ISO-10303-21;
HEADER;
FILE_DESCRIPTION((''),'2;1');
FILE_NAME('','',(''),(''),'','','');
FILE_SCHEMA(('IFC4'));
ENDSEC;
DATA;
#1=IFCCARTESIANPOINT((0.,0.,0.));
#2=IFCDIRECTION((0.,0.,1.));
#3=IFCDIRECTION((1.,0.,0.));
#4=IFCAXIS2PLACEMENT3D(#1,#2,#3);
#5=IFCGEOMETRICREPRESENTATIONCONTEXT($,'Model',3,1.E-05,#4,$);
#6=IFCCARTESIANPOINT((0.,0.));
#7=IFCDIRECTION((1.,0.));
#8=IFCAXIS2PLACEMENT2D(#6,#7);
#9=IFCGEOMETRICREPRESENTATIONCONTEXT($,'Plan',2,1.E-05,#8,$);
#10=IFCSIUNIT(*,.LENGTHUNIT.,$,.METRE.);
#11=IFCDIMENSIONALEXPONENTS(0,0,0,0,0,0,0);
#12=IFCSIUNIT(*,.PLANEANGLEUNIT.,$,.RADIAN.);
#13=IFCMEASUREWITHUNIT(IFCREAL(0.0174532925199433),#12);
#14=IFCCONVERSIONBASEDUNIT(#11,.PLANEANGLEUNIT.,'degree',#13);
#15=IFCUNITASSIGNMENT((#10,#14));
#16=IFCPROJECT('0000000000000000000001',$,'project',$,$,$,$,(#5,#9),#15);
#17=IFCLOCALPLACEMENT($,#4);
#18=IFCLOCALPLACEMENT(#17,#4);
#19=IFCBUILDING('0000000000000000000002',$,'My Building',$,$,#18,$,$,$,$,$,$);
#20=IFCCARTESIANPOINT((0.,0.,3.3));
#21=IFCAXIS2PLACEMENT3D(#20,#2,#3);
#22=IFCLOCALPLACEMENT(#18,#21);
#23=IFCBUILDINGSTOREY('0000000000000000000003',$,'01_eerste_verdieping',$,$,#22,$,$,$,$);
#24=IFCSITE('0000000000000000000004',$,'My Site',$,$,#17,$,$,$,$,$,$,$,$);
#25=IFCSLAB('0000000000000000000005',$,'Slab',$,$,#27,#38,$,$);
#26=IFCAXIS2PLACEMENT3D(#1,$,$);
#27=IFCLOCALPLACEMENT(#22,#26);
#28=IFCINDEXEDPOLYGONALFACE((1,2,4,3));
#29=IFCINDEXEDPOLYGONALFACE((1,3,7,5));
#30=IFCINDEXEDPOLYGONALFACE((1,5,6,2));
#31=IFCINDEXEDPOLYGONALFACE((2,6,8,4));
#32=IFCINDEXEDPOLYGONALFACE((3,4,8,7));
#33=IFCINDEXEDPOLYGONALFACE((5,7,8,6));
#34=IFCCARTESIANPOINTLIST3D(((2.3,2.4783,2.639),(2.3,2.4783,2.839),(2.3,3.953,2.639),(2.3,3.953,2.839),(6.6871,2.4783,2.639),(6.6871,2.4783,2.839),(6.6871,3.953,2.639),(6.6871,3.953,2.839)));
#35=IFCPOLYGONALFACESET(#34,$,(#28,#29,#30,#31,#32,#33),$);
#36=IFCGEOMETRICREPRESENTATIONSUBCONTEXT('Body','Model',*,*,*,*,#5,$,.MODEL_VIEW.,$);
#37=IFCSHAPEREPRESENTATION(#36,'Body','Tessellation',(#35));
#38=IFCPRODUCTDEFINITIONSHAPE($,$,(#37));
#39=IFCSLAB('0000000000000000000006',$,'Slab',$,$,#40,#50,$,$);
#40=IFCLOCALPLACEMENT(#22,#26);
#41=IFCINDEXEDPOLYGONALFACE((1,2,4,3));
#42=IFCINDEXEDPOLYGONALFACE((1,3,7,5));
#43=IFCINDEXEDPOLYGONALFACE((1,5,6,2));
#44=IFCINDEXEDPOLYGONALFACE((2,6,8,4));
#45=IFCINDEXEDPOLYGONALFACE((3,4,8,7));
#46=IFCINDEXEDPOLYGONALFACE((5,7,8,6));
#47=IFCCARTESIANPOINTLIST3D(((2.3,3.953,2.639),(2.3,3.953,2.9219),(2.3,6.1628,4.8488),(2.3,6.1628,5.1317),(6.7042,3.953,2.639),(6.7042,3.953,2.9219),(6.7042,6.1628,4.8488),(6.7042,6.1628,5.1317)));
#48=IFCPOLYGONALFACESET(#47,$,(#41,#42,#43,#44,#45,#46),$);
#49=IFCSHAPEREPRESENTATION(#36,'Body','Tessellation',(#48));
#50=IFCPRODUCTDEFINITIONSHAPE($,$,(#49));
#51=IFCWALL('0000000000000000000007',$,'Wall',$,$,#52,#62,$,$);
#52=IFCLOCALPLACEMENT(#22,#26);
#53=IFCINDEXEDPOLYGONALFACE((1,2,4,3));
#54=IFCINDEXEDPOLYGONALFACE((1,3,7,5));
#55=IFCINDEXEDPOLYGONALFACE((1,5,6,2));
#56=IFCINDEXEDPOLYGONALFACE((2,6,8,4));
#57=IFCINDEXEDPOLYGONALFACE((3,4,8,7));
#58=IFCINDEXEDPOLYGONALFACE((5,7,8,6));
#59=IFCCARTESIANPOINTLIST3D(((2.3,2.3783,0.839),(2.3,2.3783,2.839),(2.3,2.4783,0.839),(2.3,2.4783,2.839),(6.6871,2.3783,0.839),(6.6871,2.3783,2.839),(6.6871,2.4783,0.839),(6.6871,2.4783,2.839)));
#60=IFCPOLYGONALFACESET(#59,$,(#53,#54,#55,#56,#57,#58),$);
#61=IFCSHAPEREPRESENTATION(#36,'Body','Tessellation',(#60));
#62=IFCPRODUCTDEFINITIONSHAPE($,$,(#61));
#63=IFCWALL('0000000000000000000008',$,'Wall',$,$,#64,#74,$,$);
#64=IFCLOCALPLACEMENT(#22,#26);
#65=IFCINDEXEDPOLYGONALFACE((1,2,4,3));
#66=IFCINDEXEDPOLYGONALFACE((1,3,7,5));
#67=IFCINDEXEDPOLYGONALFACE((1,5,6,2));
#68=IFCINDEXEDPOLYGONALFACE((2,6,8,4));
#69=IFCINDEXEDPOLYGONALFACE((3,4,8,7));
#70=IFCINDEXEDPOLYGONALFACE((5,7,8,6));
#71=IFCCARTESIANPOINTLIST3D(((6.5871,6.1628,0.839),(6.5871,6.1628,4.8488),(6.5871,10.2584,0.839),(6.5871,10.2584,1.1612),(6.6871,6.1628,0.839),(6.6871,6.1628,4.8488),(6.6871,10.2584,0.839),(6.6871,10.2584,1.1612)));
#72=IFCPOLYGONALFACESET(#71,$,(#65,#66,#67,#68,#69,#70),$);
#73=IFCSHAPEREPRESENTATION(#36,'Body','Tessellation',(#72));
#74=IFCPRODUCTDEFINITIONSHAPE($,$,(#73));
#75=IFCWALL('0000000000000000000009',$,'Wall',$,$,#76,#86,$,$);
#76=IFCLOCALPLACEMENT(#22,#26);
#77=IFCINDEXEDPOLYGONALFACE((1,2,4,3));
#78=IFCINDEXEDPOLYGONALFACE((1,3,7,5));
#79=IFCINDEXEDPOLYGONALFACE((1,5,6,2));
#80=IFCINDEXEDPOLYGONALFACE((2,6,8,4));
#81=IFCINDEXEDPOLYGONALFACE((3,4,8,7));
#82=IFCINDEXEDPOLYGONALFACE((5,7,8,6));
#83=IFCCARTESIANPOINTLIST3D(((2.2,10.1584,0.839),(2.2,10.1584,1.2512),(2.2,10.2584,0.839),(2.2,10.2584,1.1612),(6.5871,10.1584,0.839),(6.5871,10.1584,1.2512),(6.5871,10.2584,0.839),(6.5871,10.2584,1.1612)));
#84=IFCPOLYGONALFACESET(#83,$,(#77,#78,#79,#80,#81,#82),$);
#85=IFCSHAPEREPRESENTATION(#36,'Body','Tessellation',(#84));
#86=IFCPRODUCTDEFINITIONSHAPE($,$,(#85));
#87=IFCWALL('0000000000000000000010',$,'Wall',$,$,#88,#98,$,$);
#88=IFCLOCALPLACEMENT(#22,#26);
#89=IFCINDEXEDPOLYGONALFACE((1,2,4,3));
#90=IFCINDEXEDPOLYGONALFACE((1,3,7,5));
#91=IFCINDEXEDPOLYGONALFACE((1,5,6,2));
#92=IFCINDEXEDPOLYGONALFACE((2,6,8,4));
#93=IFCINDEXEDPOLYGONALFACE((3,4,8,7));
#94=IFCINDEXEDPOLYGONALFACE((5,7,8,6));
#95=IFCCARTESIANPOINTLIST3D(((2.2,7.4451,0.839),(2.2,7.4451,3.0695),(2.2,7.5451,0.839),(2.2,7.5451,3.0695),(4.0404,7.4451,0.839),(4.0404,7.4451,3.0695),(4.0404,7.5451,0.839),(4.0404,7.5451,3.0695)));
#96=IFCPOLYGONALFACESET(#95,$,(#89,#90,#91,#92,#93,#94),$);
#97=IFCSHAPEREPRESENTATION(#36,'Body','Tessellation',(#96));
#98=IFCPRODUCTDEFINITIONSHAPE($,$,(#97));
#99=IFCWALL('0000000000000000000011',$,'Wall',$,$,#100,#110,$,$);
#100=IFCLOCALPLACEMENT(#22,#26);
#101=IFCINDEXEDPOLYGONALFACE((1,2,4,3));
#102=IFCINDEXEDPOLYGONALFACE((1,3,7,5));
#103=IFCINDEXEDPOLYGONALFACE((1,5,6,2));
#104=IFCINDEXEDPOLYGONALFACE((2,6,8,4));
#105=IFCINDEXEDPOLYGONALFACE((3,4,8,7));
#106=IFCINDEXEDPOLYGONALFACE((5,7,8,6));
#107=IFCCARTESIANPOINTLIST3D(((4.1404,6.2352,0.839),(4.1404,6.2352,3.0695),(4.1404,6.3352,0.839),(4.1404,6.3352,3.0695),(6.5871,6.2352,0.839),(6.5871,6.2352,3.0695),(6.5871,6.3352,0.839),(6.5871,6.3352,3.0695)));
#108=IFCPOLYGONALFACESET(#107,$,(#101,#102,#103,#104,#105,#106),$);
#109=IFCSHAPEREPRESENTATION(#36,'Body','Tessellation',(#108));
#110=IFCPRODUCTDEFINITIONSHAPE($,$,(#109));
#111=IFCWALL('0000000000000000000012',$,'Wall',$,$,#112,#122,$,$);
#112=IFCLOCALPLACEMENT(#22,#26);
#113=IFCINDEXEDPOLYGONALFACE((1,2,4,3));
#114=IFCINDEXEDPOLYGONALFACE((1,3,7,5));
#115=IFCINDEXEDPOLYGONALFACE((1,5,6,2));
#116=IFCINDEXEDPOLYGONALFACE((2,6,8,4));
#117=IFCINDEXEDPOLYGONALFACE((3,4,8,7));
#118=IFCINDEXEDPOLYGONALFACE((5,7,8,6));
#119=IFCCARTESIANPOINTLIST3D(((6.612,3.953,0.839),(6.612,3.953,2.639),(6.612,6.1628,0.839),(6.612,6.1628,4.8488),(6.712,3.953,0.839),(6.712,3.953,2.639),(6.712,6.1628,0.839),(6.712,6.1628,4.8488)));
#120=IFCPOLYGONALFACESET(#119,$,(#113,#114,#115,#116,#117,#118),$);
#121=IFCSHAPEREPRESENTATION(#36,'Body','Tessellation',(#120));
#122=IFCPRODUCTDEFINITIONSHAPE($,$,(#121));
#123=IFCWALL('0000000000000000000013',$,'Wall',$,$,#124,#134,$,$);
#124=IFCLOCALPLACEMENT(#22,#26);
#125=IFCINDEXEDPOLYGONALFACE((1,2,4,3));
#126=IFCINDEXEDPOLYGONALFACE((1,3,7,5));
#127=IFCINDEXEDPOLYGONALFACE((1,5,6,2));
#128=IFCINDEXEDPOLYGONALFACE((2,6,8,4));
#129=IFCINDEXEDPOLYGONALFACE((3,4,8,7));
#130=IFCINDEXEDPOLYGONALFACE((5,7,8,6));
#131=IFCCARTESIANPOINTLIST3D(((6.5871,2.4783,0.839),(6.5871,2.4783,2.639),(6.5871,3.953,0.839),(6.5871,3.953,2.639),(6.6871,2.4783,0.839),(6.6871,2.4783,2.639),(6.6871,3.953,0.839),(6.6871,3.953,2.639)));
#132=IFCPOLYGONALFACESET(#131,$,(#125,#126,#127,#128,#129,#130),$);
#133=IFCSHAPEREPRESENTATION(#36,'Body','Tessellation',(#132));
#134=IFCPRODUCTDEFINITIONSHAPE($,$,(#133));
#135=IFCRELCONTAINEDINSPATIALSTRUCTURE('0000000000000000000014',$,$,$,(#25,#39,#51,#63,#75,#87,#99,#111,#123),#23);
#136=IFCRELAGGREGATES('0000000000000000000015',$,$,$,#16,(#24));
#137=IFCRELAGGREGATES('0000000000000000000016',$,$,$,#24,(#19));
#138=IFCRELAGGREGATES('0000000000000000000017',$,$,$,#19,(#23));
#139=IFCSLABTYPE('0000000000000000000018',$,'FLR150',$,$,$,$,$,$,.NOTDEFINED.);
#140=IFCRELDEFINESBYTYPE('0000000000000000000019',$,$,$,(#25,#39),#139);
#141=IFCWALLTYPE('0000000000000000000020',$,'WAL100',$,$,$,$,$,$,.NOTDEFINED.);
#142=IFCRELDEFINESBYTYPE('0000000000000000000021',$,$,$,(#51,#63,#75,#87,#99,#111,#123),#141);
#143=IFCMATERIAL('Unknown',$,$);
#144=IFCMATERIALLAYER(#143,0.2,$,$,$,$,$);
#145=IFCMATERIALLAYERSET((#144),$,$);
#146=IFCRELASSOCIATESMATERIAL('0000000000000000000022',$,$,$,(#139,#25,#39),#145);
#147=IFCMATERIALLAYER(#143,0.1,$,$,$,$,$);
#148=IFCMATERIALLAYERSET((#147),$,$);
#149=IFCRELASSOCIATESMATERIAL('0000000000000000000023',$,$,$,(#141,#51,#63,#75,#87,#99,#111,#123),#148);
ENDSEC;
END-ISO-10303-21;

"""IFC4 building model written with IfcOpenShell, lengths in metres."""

from ifc_helpers import new_model, entity, si_unit, converted_unit, frame, origin_with_axes, origin_2d_with_axis, place, context, subcontext, project, spatial, line, indexed_curve, outline, extrude, clip, halfspace, material, layer, layer_set, layer_usage, type_object, element, save


model = new_model("IFC4")

# Units and contexts
model_context = context("Model", 3, precision=1e-05, world=origin_with_axes())
plan_context = context("Plan", 2, precision=1e-05, world=origin_2d_with_axis())
body_context = subcontext(model_context, "Body", "Model", "MODEL_VIEW")
ifc_project = project(units=[si_unit("LENGTHUNIT", "METRE"), converted_unit("PLANEANGLEUNIT", "degree", entity("IfcReal", 0.0174532925199433), si_unit("PLANEANGLEUNIT", "RADIAN"), dimensions=[0, 0, 0, 0, 0, 0, 0])], contexts=[model_context, plan_context])

# Site, building, storey
site_placement = place(None, origin_with_axes())
site = spatial("IfcSite", under=ifc_project, at=site_placement, Name="My Site")
building_placement = place(site_placement, origin_with_axes())
building = spatial("IfcBuilding", under=site, at=building_placement, Name="My Building")
storey_placement = place(building_placement, frame((0.0, 0.0, 3.3), z_axis=(0.0, 0.0, 1.0), x_axis=(1.0, 0.0, 0.0)))
storey = spatial("IfcBuildingStorey", under=building, at=storey_placement, Name="01_eerste_verdieping")

# Slabs
ifc_material = material(Name="Unknown")
ifc_layer_1 = layer(ifc_material, 0.2)
ifc_layer_set_1 = layer_set([ifc_layer_1])
ifc_layer_usage_1 = layer_usage(ifc_layer_set_1, "AXIS3", "POSITIVE", 0.0)
slab_type = type_object("IfcSlabType", Name="FLR150", PredefinedType="NOTDEFINED", material=ifc_layer_set_1)
slab_1_placement = place(storey_placement, frame((2.3, 2.4783, 2.639), z_axis=(0.0, 0.0, 1.0), x_axis=(1.0, 0.0, 0.0)))
element("IfcSlab", 1, at=slab_1_placement, inside=storey, type_object=slab_type, material=ifc_layer_usage_1, Name="Slab", context=body_context, shape_type="SweptSolid", body=[
    extrude(outline(indexed_curve([(0.0, 0.0), (4.3871, 0.0), (4.3871, 1.4747), (0.0, 1.4747)], segments=[line(4, 1), line(1, 2), line(2, 3), line(3, 4)], self_intersect=False)), None, (0.0, 0.0, 1.0), 0.2),
])
ifc_layer_usage_2 = layer_usage(ifc_layer_set_1, "AXIS3", "POSITIVE", 0.0)
slab_2_placement = place(storey_placement, frame((2.3, 3.953, 2.639), z_axis=(0.0, -0.707107, 0.707107), x_axis=(1.0, 0.0, 0.0)))
element("IfcSlab", 2, at=slab_2_placement, inside=storey, type_object=slab_type, material=ifc_layer_usage_2, Name="Slab", context=body_context, shape_type="SweptSolid", body=[
    extrude(outline(indexed_curve([(4.4042, 0.0), (0.0, 0.0), (0.0, 3.1252), (4.4042, 3.1252)], segments=[line(4, 1), line(1, 2), line(2, 3), line(3, 4)], self_intersect=False)), None, (0.0, 0.707107, 0.707107), 0.2828),
])

# Walls
ifc_layer_2 = layer(ifc_material, 0.1)
ifc_layer_set_2 = layer_set([ifc_layer_2])
ifc_layer_usage_3 = layer_usage(ifc_layer_set_2, "AXIS2", "POSITIVE", 0.0)
wall_type = type_object("IfcWallType", Name="WAL100", PredefinedType="NOTDEFINED", material=ifc_layer_set_2)
wall_1_placement = place(storey_placement, frame((2.3, 2.3783, 0.839), z_axis=(0.0, 0.0, 1.0), x_axis=(1.0, 0.0, 0.0)))
element("IfcWall", 3, at=wall_1_placement, inside=storey, type_object=wall_type, material=ifc_layer_usage_3, Name="Wall", context=body_context, shape_type="SweptSolid", body=[
    extrude(outline(indexed_curve([(0.0, 0.0), (0.0, 0.1), (4.3871, 0.1), (4.3871, 0.0), (0.0, 0.0)], self_intersect=False)), origin_with_axes(), (0.0, 0.0, 1.0), 2.0),
])
ifc_layer_usage_4 = layer_usage(ifc_layer_set_2, "AXIS2", "POSITIVE", 0.0)
wall_2_placement = place(storey_placement, frame((6.5871, 10.2584, 0.839), z_axis=(0.0, 0.0, 1.0), x_axis=(0.0, -1.0, 0.0)))
element("IfcWall", 4, at=wall_2_placement, inside=storey, type_object=wall_type, material=ifc_layer_usage_4, Name="Wall", context=body_context, shape_type="Clipping", body=[
    clip(extrude(outline(indexed_curve([(0.0, 0.0), (0.0, 0.1), (4.0956, 0.1), (4.0956, 0.0), (0.0, 0.0)], self_intersect=False)), origin_with_axes(), (0.0, 0.0, 1.0), 8.1488), halfspace(frame((4.0956, 0.0, 4.0098), z_axis=(-0.669131, 0.0, 0.743145), x_axis=(0.0, 1.0, 0.0)), False)),
])
ifc_layer_usage_5 = layer_usage(ifc_layer_set_2, "AXIS2", "POSITIVE", 0.0)
wall_3_placement = place(storey_placement, frame((6.5871, 10.2584, 0.839), z_axis=(0.0, 0.0, 1.0), x_axis=(-1.0, 0.0, 0.0)))
element("IfcWall", 5, at=wall_3_placement, inside=storey, type_object=wall_type, material=ifc_layer_usage_5, Name="Wall", context=body_context, shape_type="Clipping", body=[
    clip(extrude(outline(indexed_curve([(0.0, 0.0), (0.0, 0.1), (4.3871, 0.1), (4.3871, 0.0), (0.0, 0.0)], self_intersect=False)), origin_with_axes(), (0.0, 0.0, 1.0), 4.5512), halfspace(frame((0.0, 0.1, 0.4122), z_axis=(0.0, -0.669131, 0.743145), x_axis=(-1.0, 0.0, 0.0)), False)),
])
ifc_layer_usage_6 = layer_usage(ifc_layer_set_2, "AXIS2", "POSITIVE", 0.0)
wall_4_placement = place(storey_placement, frame((2.2, 7.4451, 0.839), z_axis=(0.0, 0.0, 1.0), x_axis=(1.0, -0.000001, 0.0)))
element("IfcWall", 6, at=wall_4_placement, inside=storey, type_object=wall_type, material=ifc_layer_usage_6, Name="Wall", context=body_context, shape_type="Clipping", body=[
    clip(extrude(outline(indexed_curve([(0.0, 0.0), (0.0, 0.1), (1.8404, 0.1), (1.8404, 0.0), (0.0, 0.0)], self_intersect=False)), origin_with_axes(), (0.0, 0.0, 1.0), 6.3695), halfspace(frame((0.0, 0.0, 2.2305), z_axis=(0.0, 0.0, 1.0), x_axis=(-1.0, 0.0, 0.0)), False)),
])
ifc_layer_usage_7 = layer_usage(ifc_layer_set_2, "AXIS2", "POSITIVE", 0.0)
wall_5_placement = place(storey_placement, frame((4.1404, 6.2352, 0.839), z_axis=(0.0, 0.0, 1.0), x_axis=(1.0, 0.0, 0.0)))
element("IfcWall", 7, at=wall_5_placement, inside=storey, type_object=wall_type, material=ifc_layer_usage_7, Name="Wall", context=body_context, shape_type="Clipping", body=[
    clip(extrude(outline(indexed_curve([(0.0, 0.0), (0.0, 0.1), (2.4466, 0.1), (2.4466, 0.0), (0.0, 0.0)], self_intersect=False)), origin_with_axes(), (0.0, 0.0, 1.0), 6.3695), halfspace(frame((0.0, 0.0, 2.2305), z_axis=(0.0, 0.0, 1.0), x_axis=(-1.0, 0.0, 0.0)), False)),
])
ifc_layer_usage_8 = layer_usage(ifc_layer_set_2, "AXIS2", "POSITIVE", 0.0)
wall_6_placement = place(storey_placement, frame((6.712, 3.953, 0.839), z_axis=(0.0, 0.0, 1.0), x_axis=(0.0, 1.0, 0.0)))
element("IfcWall", 8, at=wall_6_placement, inside=storey, type_object=wall_type, material=ifc_layer_usage_8, Name="Wall", context=body_context, shape_type="Clipping", body=[
    clip(extrude(outline(indexed_curve([(0.0, 0.0), (0.0, 0.1), (2.2098, 0.1), (2.2098, 0.0), (0.0, 0.0)], self_intersect=False)), origin_with_axes(), (0.0, 0.0, 1.0), 8.1488), halfspace(frame((2.2098, 0.0, 4.0098), z_axis=(-0.707107, 0.0, 0.707107), x_axis=(0.0, 1.0, 0.0)), False)),
])
ifc_layer_usage_9 = layer_usage(ifc_layer_set_2, "AXIS2", "POSITIVE", 0.0)
wall_7_placement = place(storey_placement, frame((6.6871, 2.4783, 0.839), z_axis=(0.0, 0.0, 1.0), x_axis=(0.0, 1.0, 0.0)))
element("IfcWall", 9, at=wall_7_placement, inside=storey, type_object=wall_type, material=ifc_layer_usage_9, Name="Wall", context=body_context, shape_type="Clipping", body=[
    clip(extrude(outline(indexed_curve([(0.0, 0.0), (0.0, 0.1), (1.4747, 0.1), (1.4747, 0.0), (0.0, 0.0)], self_intersect=False)), origin_with_axes(), (0.0, 0.0, 1.0), 5.939), halfspace(frame((0.0, 0.0, 1.8), z_axis=(0.0, 0.0, 1.0), x_axis=(-1.0, 0.0, 0.0)), False)),
])

save(model, "model.ifc")
